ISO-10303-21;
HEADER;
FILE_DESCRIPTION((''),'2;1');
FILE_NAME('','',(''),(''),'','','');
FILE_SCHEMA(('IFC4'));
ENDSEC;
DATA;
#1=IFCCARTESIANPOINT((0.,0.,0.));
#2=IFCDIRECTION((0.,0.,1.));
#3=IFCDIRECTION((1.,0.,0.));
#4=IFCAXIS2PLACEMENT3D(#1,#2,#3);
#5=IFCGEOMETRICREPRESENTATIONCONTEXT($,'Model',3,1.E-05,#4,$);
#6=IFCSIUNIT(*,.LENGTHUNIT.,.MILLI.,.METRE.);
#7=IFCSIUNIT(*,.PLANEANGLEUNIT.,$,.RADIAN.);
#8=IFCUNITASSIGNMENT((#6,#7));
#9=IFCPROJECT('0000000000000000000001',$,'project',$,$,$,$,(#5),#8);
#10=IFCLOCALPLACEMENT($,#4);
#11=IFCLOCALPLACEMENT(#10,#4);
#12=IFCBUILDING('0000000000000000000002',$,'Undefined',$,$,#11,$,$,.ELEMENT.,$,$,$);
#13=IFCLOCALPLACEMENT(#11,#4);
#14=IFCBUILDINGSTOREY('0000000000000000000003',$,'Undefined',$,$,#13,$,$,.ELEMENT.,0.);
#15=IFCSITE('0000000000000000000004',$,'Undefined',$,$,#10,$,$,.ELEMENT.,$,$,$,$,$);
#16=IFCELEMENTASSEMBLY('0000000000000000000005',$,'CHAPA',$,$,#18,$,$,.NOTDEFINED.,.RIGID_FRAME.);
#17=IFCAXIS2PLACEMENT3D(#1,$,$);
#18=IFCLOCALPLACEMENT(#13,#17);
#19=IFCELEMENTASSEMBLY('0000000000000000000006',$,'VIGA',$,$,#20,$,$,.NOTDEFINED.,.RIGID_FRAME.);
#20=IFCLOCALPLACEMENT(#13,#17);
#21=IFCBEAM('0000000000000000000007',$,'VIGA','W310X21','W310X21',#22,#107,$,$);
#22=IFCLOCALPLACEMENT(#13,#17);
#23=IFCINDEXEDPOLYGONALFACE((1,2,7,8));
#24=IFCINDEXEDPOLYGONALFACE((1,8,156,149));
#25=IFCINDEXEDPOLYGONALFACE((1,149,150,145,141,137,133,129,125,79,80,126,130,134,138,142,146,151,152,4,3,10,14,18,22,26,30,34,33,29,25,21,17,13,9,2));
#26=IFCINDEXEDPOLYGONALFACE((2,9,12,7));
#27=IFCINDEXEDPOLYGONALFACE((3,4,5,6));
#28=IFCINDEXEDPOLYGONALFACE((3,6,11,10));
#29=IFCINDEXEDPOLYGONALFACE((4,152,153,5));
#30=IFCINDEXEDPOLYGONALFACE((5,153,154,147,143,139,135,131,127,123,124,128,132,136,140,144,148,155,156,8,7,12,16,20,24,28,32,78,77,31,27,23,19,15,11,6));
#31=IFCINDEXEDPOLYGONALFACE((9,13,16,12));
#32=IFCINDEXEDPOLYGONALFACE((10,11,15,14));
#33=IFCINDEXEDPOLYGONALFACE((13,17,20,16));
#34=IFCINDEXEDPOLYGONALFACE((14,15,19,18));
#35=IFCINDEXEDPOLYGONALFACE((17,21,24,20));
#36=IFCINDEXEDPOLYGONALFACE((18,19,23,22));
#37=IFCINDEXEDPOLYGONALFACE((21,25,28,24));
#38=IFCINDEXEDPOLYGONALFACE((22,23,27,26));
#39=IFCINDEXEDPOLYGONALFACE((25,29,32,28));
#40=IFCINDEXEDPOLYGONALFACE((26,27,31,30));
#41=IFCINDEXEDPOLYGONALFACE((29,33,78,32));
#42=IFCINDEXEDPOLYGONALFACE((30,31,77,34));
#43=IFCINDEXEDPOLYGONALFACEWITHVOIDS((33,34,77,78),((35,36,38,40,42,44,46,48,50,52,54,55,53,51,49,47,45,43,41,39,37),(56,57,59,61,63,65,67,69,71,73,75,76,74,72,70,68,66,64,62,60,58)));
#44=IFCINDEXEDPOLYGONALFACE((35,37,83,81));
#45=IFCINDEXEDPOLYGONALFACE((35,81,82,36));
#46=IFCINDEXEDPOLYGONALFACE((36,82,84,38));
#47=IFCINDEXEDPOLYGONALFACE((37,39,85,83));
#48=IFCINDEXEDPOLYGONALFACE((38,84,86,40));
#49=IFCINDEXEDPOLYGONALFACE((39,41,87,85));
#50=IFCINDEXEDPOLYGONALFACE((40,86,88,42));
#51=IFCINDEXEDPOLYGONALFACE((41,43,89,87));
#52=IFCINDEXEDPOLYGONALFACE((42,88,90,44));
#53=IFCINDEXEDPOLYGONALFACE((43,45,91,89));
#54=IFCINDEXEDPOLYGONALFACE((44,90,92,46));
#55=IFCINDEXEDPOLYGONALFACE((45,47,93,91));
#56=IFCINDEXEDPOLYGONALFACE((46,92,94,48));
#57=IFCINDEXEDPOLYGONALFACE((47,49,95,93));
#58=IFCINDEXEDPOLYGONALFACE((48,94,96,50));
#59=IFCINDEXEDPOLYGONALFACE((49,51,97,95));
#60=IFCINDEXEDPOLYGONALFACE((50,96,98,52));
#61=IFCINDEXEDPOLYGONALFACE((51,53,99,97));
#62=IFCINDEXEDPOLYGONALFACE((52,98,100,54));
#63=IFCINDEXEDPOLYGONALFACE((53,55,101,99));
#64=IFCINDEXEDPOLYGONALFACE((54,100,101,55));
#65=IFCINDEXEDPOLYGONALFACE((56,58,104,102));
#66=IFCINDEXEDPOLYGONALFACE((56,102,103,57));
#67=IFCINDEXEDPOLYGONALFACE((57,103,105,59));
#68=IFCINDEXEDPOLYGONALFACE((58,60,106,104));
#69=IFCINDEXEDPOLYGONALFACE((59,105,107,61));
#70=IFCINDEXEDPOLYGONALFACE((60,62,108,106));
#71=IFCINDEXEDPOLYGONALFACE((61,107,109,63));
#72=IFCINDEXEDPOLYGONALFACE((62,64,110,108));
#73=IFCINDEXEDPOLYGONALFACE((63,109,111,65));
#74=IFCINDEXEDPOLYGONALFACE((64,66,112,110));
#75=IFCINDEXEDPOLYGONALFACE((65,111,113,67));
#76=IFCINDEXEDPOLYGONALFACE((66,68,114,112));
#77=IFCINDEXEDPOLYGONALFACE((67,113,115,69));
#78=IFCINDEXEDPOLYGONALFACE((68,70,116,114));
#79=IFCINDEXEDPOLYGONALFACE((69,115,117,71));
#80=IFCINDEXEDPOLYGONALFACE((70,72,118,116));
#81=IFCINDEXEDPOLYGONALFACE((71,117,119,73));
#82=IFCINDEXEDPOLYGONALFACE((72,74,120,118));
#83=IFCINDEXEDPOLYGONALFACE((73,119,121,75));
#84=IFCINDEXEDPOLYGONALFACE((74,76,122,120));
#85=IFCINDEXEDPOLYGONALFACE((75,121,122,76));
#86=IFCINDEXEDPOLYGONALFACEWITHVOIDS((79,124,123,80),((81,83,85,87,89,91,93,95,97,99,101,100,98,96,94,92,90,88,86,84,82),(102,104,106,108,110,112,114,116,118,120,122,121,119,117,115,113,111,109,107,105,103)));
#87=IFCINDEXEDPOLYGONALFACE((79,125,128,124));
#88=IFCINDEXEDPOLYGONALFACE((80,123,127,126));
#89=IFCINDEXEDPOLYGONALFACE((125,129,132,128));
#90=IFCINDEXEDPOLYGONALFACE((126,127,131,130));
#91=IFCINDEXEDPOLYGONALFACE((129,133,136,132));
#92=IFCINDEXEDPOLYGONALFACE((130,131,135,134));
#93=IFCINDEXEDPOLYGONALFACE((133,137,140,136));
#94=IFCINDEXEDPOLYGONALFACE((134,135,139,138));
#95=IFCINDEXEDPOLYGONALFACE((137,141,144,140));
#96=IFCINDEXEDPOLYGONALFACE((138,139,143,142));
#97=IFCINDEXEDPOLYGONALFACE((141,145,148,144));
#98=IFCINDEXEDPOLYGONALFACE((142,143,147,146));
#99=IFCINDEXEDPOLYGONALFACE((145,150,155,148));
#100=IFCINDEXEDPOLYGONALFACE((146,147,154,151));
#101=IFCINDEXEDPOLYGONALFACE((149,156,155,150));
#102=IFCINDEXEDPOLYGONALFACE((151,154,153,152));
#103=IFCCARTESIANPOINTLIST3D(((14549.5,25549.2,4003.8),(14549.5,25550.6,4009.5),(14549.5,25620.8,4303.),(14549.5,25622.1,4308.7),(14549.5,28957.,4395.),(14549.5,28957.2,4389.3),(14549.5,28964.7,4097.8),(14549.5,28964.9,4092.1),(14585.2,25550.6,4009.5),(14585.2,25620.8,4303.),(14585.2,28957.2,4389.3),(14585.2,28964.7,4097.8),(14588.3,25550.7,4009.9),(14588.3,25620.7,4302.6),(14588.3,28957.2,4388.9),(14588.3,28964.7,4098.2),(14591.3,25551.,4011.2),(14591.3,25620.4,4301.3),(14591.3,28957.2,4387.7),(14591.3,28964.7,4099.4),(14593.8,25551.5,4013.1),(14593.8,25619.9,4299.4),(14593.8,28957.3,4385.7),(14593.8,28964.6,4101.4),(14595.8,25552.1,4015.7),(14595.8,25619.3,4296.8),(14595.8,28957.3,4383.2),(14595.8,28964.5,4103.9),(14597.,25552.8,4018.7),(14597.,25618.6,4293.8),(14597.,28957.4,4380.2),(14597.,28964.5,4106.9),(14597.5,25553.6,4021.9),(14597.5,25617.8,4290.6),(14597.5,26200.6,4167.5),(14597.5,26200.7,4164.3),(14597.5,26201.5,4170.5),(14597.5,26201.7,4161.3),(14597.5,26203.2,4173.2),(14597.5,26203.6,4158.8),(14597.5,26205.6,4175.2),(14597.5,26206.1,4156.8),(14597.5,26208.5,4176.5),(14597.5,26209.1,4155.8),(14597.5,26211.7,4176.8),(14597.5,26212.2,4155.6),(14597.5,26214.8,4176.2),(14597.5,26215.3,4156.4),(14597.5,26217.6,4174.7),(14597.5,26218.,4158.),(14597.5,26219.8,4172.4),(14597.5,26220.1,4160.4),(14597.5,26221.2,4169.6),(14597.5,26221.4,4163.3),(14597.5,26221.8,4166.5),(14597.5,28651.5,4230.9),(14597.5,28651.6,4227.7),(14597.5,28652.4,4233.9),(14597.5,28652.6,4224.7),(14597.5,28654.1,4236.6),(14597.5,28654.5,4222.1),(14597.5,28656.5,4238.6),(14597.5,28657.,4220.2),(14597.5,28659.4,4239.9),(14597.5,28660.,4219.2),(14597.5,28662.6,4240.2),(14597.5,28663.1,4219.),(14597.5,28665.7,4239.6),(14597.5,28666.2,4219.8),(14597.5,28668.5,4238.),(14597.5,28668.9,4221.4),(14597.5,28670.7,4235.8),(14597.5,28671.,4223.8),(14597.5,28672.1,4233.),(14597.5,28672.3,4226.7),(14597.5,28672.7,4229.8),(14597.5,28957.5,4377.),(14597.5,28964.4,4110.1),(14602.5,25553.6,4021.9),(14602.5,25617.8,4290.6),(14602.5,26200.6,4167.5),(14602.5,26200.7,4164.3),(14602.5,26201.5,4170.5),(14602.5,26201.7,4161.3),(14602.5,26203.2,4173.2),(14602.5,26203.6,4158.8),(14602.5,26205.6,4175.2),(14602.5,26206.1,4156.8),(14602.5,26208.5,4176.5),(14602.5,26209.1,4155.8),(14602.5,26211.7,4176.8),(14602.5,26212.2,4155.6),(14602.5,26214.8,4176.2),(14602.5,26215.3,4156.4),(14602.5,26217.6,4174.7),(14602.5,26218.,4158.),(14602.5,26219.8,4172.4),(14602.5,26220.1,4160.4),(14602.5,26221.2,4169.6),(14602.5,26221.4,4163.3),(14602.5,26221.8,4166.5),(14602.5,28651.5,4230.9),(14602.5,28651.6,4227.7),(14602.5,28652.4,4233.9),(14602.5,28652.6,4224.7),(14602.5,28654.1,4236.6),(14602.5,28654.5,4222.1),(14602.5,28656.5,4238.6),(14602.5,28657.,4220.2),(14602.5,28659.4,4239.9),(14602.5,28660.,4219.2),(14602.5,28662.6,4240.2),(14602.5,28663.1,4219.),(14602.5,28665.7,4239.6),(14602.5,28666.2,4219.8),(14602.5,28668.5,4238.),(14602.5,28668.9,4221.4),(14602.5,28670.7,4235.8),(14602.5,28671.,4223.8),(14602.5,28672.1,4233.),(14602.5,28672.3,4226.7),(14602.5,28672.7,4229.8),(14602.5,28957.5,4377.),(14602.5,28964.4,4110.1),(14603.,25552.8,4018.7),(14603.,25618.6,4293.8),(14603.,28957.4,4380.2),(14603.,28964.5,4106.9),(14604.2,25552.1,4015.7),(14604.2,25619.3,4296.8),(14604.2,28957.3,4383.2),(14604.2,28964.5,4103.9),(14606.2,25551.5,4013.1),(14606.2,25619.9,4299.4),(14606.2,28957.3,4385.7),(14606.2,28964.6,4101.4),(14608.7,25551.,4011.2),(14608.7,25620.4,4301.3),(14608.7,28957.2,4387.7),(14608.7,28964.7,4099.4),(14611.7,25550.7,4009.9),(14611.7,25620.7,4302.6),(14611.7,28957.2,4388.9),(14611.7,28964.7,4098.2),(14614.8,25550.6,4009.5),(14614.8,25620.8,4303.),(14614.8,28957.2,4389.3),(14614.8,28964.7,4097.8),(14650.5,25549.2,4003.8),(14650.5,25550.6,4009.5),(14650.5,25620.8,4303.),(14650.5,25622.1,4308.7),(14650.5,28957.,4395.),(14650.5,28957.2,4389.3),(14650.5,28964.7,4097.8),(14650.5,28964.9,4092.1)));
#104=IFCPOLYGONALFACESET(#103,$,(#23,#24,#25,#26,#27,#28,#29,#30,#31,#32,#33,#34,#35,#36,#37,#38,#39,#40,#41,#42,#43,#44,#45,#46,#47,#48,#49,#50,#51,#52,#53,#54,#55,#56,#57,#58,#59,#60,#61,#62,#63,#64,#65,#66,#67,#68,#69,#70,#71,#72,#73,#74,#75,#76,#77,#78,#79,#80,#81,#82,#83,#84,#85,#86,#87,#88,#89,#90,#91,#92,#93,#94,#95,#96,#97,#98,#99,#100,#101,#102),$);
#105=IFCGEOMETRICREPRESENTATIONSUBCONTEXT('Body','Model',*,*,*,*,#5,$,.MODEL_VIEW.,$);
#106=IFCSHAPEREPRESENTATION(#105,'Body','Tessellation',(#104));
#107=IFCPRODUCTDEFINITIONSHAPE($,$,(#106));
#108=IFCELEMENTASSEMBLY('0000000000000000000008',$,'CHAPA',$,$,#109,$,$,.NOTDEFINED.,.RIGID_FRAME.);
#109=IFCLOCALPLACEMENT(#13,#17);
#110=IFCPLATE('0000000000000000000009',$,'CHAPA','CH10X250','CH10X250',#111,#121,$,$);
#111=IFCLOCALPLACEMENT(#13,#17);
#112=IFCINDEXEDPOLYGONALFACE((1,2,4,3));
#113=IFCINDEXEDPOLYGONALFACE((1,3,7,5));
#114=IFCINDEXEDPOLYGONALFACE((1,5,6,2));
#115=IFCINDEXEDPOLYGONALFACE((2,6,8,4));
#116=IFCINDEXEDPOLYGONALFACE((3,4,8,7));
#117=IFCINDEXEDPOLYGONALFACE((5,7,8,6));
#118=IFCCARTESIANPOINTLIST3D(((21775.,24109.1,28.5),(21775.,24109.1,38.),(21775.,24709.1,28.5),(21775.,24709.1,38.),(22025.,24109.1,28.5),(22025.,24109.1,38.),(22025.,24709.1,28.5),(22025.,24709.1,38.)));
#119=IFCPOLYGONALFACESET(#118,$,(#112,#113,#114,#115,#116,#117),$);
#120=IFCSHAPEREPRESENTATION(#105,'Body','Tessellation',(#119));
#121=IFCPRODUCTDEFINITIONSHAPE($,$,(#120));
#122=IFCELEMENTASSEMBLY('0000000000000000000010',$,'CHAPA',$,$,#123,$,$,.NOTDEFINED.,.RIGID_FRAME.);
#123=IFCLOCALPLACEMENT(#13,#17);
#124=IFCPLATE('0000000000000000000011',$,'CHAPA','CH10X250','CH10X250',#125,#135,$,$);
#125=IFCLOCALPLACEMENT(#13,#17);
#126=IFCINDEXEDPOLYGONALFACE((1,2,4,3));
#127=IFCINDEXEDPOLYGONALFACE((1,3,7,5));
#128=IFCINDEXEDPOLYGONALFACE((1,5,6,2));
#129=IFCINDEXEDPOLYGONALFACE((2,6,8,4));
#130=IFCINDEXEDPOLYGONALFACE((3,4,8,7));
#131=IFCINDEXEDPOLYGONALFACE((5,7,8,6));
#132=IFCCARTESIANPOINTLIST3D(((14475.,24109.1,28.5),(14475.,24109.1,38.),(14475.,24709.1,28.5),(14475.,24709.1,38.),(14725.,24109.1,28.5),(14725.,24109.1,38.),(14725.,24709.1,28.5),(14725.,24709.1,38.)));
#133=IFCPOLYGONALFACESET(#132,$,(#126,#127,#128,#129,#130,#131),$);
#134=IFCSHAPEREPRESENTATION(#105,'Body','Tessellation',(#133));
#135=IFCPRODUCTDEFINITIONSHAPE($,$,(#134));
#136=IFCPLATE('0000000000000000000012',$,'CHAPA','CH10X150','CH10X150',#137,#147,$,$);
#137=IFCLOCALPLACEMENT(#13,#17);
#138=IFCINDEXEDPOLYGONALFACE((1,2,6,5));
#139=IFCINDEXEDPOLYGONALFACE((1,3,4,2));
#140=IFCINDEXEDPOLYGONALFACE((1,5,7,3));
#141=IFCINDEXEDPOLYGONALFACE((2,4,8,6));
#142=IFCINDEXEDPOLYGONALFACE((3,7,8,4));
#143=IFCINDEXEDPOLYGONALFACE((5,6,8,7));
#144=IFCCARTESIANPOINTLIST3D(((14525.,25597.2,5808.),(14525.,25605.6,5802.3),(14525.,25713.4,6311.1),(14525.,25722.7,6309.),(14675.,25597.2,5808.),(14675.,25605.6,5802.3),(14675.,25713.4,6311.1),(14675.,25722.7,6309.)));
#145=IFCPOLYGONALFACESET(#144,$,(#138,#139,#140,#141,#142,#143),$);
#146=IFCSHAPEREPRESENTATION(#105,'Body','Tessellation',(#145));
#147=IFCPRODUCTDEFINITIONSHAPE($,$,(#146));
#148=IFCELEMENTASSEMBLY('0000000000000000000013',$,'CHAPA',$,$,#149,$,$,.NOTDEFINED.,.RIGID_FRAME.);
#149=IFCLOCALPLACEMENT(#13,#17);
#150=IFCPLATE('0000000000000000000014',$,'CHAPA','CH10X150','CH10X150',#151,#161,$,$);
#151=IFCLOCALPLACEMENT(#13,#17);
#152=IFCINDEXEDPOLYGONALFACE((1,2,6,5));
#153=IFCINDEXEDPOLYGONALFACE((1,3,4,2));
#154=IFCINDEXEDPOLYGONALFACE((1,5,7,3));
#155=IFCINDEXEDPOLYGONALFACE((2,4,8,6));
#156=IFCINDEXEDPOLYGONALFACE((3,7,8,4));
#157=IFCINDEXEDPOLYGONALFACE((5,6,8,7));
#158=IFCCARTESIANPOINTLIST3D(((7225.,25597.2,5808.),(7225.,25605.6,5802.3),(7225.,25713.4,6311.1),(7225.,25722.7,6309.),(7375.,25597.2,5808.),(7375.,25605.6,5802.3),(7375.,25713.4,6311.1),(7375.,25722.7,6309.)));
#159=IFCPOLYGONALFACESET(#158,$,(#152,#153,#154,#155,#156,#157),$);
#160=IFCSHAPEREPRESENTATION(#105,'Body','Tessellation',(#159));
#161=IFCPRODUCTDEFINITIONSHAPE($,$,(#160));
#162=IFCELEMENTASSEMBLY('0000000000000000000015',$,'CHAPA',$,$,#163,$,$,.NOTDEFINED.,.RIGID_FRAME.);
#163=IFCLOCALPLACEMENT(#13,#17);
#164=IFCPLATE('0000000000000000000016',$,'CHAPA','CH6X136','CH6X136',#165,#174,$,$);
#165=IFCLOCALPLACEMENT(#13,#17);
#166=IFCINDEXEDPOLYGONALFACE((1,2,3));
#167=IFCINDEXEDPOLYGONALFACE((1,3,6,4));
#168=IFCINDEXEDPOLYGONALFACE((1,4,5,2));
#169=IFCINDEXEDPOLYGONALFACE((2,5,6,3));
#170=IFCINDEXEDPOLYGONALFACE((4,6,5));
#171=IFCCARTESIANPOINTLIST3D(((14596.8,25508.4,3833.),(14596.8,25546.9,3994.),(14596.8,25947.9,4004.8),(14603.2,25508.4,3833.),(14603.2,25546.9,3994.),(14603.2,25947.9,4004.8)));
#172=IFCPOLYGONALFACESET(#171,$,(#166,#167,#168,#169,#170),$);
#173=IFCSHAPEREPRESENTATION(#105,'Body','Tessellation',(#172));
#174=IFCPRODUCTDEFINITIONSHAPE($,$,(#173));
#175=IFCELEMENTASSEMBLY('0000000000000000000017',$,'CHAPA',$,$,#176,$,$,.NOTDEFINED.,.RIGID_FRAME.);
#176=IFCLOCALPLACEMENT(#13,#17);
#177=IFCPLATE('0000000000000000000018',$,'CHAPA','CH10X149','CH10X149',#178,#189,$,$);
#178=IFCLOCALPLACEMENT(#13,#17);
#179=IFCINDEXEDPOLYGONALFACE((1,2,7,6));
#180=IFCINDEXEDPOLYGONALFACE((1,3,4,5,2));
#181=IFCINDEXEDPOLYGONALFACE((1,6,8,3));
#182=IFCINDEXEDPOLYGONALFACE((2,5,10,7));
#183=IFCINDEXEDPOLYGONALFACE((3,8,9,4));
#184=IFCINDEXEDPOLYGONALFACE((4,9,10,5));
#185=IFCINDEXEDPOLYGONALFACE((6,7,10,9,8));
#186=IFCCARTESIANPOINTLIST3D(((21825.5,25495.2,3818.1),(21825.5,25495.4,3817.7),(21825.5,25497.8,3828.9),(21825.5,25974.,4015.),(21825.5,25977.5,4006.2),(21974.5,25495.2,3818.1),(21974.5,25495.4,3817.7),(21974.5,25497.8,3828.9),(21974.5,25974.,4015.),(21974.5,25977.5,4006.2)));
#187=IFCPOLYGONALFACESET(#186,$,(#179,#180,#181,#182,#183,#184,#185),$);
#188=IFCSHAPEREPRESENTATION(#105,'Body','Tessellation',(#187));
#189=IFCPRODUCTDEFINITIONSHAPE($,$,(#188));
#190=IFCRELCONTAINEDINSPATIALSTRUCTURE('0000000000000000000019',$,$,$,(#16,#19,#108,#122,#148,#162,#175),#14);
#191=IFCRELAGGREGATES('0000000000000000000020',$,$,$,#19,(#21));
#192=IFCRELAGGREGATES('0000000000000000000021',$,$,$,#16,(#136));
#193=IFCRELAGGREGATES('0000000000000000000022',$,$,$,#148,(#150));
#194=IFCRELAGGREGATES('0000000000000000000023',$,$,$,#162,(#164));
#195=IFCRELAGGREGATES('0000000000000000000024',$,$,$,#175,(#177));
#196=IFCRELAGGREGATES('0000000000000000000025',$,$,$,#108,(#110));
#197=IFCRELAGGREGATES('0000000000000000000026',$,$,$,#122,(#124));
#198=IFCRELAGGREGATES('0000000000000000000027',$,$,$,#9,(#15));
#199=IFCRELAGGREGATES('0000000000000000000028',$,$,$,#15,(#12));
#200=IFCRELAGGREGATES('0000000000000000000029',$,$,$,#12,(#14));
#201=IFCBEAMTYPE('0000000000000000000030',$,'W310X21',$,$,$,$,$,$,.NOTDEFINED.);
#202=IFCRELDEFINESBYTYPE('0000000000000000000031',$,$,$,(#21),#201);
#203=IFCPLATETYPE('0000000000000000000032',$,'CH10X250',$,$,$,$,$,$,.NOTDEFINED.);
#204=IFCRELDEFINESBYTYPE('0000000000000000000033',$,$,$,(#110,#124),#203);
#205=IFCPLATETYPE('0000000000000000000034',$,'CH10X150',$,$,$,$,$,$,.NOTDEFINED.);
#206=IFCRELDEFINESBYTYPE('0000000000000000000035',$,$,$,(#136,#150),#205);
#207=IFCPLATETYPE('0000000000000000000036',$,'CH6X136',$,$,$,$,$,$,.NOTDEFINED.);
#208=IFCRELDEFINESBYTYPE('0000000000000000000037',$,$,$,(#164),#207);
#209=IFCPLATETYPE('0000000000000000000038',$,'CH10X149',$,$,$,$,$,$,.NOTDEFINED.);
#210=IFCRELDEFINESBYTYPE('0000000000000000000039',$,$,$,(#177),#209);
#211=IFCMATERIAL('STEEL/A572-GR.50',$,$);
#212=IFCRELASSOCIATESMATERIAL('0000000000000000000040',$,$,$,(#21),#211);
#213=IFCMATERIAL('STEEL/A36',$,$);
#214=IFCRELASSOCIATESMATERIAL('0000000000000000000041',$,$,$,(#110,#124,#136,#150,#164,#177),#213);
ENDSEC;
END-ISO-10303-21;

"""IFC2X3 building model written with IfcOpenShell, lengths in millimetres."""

from ifc_helpers import new_model, si_unit, frame, origin_with_axes, origin_2d_with_axis, place, context, subcontext, project, spatial, polyline, circle, i_section, outline, extrude, boolean, clip, halfspace, material, type_object, element, aggregate, save


model = new_model("IFC2X3")

# Units and contexts
model_context = context("Model", 3, precision=1e-05, world=origin_with_axes())
body_context = subcontext(model_context, "Body", "Model", "MODEL_VIEW")
ifc_project = project(units=[si_unit("LENGTHUNIT", "METRE", prefix="MILLI"), si_unit("PLANEANGLEUNIT", "RADIAN")], contexts=[model_context])

# Site, building, storey
site_placement = place(None, origin_with_axes())
site = spatial("IfcSite", under=ifc_project, at=site_placement, Name="Undefined", CompositionType="ELEMENT")
building_placement = place(site_placement, origin_with_axes())
building = spatial("IfcBuilding", under=site, at=building_placement, Name="Undefined", CompositionType="ELEMENT")
storey_placement = place(building_placement, origin_with_axes())
storey = spatial("IfcBuildingStorey", under=building, at=storey_placement, Name="Undefined", CompositionType="ELEMENT", Elevation=0.0)

# Element assemblies, beam
assembly_1_placement = place(storey_placement, origin_with_axes())
assembly_1 = element("IfcElementAssembly", 1, at=assembly_1_placement, inside=storey, Name="CHAPA", AssemblyPlace="NOTDEFINED", PredefinedType="RIGID_FRAME")
ifc_material_1 = material(Name="STEEL/A572-GR.50")
assembly_2_placement = place(storey_placement, origin_with_axes())
assembly_2 = element("IfcElementAssembly", 2, at=assembly_2_placement, inside=storey, Name="VIGA", AssemblyPlace="NOTDEFINED", PredefinedType="RIGID_FRAME")
beam_type_1 = type_object("IfcBeamType", Name="W310X21", PredefinedType="NOTDEFINED")
beam_1_placement = place(assembly_2_placement, frame((14600.0, 25403.9, 4151.6), z_axis=(0.0, -0.025855, 0.999666), x_axis=(0.0, 0.999666, 0.025855)))
beam_1 = element("IfcBeam", 3, at=beam_1_placement, type_object=beam_type_1, material=ifc_material_1, Name="VIGA", Description="W310X21", ObjectType="W310X21", context=body_context, shape_type="CSG", body=[
    boolean("DIFFERENCE", boolean("DIFFERENCE", boolean("DIFFERENCE", extrude(i_section(OverallWidth=101.0, OverallDepth=303.0, WebThickness=5.1, FlangeThickness=5.7, FilletRadius=12.3, at=origin_2d_with_axis()), frame((3558.2, 0.0, 0.0), z_axis=(-1.0, 0.0, 0.0), x_axis=(0.0, -1.0, 0.0)), (0.0, 0.0, 1.0), 3558.2), extrude(circle(Radius=10.6, at=origin_2d_with_axis()), frame((3259.1, -100.0, -6.3), z_axis=(0.0, 1.0, 0.0), x_axis=(1.0, 0.0, 0.0)), (0.0, 0.0, 1.0), 200.0)), extrude(circle(Radius=10.6, at=origin_2d_with_axis()), frame((807.4, -100.0, -6.2), z_axis=(0.0, 1.0, 0.0), x_axis=(1.0, 0.0, 0.0)), (0.0, 0.0, 1.0), 200.0)), halfspace(frame((141.4, -50.5, -151.7), z_axis=(-0.966259, 0.0, 0.257573), x_axis=(0.0, 1.0, 0.0)), False)),
])
aggregate(assembly_2, [beam_1])

# Element assemblies, plates
assembly_3_placement = place(storey_placement, origin_with_axes())
assembly_3 = element("IfcElementAssembly", 4, at=assembly_3_placement, inside=storey, Name="CHAPA", AssemblyPlace="NOTDEFINED", PredefinedType="RIGID_FRAME")
ifc_material_2 = material(Name="STEEL/A36")
plate_type_1 = type_object("IfcPlateType", Name="CH10X250", PredefinedType="NOTDEFINED")
plate_1_placement = place(assembly_3_placement, frame((21775.0, 24709.1, 33.2), z_axis=(0.0, 0.0, -1.0), x_axis=(1.0, 0.0, 0.0)))
plate_1 = element("IfcPlate", 5, at=plate_1_placement, type_object=plate_type_1, material=ifc_material_2, Name="CHAPA", Description="CH10X250", ObjectType="CH10X250", context=body_context, shape_type="SweptSolid", body=[
    extrude(outline(polyline([(0.0, 0.0), (250.0, 0.0), (250.0, 600.0), (0.0, 600.0), (0.0, 0.0)])), frame((0.0, 0.0, -4.8), z_axis=(0.0, 0.0, 1.0), x_axis=(1.0, 0.0, 0.0)), (0.0, 0.0, 1.0), 9.5),
])
assembly_4_placement = place(storey_placement, origin_with_axes())
assembly_4 = element("IfcElementAssembly", 6, at=assembly_4_placement, inside=storey, Name="CHAPA", AssemblyPlace="NOTDEFINED", PredefinedType="RIGID_FRAME")
plate_2_placement = place(assembly_4_placement, frame((14475.0, 24709.1, 33.2), z_axis=(0.0, 0.0, -1.0), x_axis=(1.0, 0.0, 0.0)))
plate_2 = element("IfcPlate", 7, at=plate_2_placement, type_object=plate_type_1, material=ifc_material_2, Name="CHAPA", Description="CH10X250", ObjectType="CH10X250", context=body_context, shape_type="SweptSolid", body=[
    extrude(outline(polyline([(0.0, 0.0), (250.0, 0.0), (250.0, 600.0), (0.0, 600.0), (0.0, 0.0)])), frame((0.0, 0.0, -4.8), z_axis=(0.0, 0.0, 1.0), x_axis=(1.0, 0.0, 0.0)), (0.0, 0.0, 1.0), 9.5),
])

# Plate
plate_type_2 = type_object("IfcPlateType", Name="CH10X150", PredefinedType="NOTDEFINED")
plate_3_placement = place(assembly_1_placement, frame((14675.0, 25718.1, 6310.1), z_axis=(0.0, 0.97433, -0.225124), x_axis=(0.0, -0.225124, -0.97433)))
plate_3 = element("IfcPlate", 8, at=plate_3_placement, type_object=plate_type_2, material=ifc_material_2, Name="CHAPA", Description="CH10X150", ObjectType="CH10X150", context=body_context, shape_type="Clipping", body=[
    clip(extrude(outline(polyline([(0.0, 0.0), (520.0, 0.0), (520.0, 150.0), (0.0, 150.0), (0.0, 0.0)])), frame((0.0, 0.0, -4.8), z_axis=(0.0, 0.0, 1.0), x_axis=(1.0, 0.0, 0.0)), (0.0, 0.0, 1.0), 9.5), halfspace(frame((516.4, -500.0, -4.7), z_axis=(0.934951, 0.0, -0.354778), x_axis=(0.354778, 0.0, 0.934951)), False)),
])
aggregate(assembly_1, [plate_3])

# Element assemblies, plates
assembly_5_placement = place(storey_placement, origin_with_axes())
assembly_5 = element("IfcElementAssembly", 9, at=assembly_5_placement, inside=storey, Name="CHAPA", AssemblyPlace="NOTDEFINED", PredefinedType="RIGID_FRAME")
plate_4_placement = place(assembly_5_placement, frame((7375.0, 25718.1, 6310.1), z_axis=(0.0, 0.97433, -0.225124), x_axis=(0.0, -0.225124, -0.97433)))
plate_4 = element("IfcPlate", 10, at=plate_4_placement, type_object=plate_type_2, material=ifc_material_2, Name="CHAPA", Description="CH10X150", ObjectType="CH10X150", context=body_context, shape_type="Clipping", body=[
    clip(extrude(outline(polyline([(0.0, 0.0), (520.0, 0.0), (520.0, 150.0), (0.0, 150.0), (0.0, 0.0)])), frame((0.0, 0.0, -4.8), z_axis=(0.0, 0.0, 1.0), x_axis=(1.0, 0.0, 0.0)), (0.0, 0.0, 1.0), 9.5), halfspace(frame((516.4, -500.0, -4.7), z_axis=(0.934951, 0.0, -0.354778), x_axis=(0.354778, 0.0, 0.934951)), False)),
])
aggregate(assembly_5, [plate_4])
assembly_6_placement = place(storey_placement, origin_with_axes())
assembly_6 = element("IfcElementAssembly", 11, at=assembly_6_placement, inside=storey, Name="CHAPA", AssemblyPlace="NOTDEFINED", PredefinedType="RIGID_FRAME")
plate_type_3 = type_object("IfcPlateType", Name="CH6X136", PredefinedType="NOTDEFINED")
plate_5_placement = place(assembly_6_placement, frame((14600.0, 25546.9, 3994.0), z_axis=(-1.0, 0.0, 0.0), x_axis=(0.0, 0.999636, 0.026972)))
plate_5 = element("IfcPlate", 12, at=plate_5_placement, type_object=plate_type_3, material=ifc_material_2, Name="CHAPA", Description="CH6X136", ObjectType="CH6X136", context=body_context, shape_type="SweptSolid", body=[
    extrude(outline(polyline([(0.0, 0.0), (401.1, 0.0), (-42.8, 159.9), (0.0, 0.0)])), frame((0.0, 0.0, -3.1), z_axis=(0.0, 0.0, 1.0), x_axis=(1.0, 0.0, 0.0)), (0.0, 0.0, 1.0), 6.3),
])
aggregate(assembly_6, [plate_5])
assembly_7_placement = place(storey_placement, origin_with_axes())
assembly_7 = element("IfcElementAssembly", 13, at=assembly_7_placement, inside=storey, Name="CHAPA", AssemblyPlace="NOTDEFINED", PredefinedType="RIGID_FRAME")
plate_type_4 = type_object("IfcPlateType", Name="CH10X149", PredefinedType="NOTDEFINED")
plate_6_placement = place(assembly_7_placement, frame((21825.5, 25975.7, 4010.6), z_axis=(0.0, 0.364063, -0.931374), x_axis=(1.0, 0.0, 0.0)))
plate_6 = element("IfcPlate", 14, at=plate_6_placement, type_object=plate_type_4, material=ifc_material_2, Name="CHAPA", Description="CH10X149", ObjectType="CH10X149", context=body_context, shape_type="Clipping", body=[
    clip(extrude(outline(polyline([(0.0, 0.0), (149.0, 0.0), (149.0, 517.6), (0.0, 517.6), (0.0, 0.0)])), frame((0.0, 0.0, -4.8), z_axis=(0.0, 0.0, 1.0), x_axis=(1.0, 0.0, 0.0)), (0.0, 0.0, 1.0), 9.5), halfspace(frame((149.0, 517.9, 4.7), z_axis=(0.0, 0.821204, -0.570634), x_axis=(-1.0, 0.0, 0.0)), False)),
])
aggregate(assembly_7, [plate_6])

aggregate(assembly_3, [plate_1])
aggregate(assembly_4, [plate_2])

save(model, "model.ifc")
